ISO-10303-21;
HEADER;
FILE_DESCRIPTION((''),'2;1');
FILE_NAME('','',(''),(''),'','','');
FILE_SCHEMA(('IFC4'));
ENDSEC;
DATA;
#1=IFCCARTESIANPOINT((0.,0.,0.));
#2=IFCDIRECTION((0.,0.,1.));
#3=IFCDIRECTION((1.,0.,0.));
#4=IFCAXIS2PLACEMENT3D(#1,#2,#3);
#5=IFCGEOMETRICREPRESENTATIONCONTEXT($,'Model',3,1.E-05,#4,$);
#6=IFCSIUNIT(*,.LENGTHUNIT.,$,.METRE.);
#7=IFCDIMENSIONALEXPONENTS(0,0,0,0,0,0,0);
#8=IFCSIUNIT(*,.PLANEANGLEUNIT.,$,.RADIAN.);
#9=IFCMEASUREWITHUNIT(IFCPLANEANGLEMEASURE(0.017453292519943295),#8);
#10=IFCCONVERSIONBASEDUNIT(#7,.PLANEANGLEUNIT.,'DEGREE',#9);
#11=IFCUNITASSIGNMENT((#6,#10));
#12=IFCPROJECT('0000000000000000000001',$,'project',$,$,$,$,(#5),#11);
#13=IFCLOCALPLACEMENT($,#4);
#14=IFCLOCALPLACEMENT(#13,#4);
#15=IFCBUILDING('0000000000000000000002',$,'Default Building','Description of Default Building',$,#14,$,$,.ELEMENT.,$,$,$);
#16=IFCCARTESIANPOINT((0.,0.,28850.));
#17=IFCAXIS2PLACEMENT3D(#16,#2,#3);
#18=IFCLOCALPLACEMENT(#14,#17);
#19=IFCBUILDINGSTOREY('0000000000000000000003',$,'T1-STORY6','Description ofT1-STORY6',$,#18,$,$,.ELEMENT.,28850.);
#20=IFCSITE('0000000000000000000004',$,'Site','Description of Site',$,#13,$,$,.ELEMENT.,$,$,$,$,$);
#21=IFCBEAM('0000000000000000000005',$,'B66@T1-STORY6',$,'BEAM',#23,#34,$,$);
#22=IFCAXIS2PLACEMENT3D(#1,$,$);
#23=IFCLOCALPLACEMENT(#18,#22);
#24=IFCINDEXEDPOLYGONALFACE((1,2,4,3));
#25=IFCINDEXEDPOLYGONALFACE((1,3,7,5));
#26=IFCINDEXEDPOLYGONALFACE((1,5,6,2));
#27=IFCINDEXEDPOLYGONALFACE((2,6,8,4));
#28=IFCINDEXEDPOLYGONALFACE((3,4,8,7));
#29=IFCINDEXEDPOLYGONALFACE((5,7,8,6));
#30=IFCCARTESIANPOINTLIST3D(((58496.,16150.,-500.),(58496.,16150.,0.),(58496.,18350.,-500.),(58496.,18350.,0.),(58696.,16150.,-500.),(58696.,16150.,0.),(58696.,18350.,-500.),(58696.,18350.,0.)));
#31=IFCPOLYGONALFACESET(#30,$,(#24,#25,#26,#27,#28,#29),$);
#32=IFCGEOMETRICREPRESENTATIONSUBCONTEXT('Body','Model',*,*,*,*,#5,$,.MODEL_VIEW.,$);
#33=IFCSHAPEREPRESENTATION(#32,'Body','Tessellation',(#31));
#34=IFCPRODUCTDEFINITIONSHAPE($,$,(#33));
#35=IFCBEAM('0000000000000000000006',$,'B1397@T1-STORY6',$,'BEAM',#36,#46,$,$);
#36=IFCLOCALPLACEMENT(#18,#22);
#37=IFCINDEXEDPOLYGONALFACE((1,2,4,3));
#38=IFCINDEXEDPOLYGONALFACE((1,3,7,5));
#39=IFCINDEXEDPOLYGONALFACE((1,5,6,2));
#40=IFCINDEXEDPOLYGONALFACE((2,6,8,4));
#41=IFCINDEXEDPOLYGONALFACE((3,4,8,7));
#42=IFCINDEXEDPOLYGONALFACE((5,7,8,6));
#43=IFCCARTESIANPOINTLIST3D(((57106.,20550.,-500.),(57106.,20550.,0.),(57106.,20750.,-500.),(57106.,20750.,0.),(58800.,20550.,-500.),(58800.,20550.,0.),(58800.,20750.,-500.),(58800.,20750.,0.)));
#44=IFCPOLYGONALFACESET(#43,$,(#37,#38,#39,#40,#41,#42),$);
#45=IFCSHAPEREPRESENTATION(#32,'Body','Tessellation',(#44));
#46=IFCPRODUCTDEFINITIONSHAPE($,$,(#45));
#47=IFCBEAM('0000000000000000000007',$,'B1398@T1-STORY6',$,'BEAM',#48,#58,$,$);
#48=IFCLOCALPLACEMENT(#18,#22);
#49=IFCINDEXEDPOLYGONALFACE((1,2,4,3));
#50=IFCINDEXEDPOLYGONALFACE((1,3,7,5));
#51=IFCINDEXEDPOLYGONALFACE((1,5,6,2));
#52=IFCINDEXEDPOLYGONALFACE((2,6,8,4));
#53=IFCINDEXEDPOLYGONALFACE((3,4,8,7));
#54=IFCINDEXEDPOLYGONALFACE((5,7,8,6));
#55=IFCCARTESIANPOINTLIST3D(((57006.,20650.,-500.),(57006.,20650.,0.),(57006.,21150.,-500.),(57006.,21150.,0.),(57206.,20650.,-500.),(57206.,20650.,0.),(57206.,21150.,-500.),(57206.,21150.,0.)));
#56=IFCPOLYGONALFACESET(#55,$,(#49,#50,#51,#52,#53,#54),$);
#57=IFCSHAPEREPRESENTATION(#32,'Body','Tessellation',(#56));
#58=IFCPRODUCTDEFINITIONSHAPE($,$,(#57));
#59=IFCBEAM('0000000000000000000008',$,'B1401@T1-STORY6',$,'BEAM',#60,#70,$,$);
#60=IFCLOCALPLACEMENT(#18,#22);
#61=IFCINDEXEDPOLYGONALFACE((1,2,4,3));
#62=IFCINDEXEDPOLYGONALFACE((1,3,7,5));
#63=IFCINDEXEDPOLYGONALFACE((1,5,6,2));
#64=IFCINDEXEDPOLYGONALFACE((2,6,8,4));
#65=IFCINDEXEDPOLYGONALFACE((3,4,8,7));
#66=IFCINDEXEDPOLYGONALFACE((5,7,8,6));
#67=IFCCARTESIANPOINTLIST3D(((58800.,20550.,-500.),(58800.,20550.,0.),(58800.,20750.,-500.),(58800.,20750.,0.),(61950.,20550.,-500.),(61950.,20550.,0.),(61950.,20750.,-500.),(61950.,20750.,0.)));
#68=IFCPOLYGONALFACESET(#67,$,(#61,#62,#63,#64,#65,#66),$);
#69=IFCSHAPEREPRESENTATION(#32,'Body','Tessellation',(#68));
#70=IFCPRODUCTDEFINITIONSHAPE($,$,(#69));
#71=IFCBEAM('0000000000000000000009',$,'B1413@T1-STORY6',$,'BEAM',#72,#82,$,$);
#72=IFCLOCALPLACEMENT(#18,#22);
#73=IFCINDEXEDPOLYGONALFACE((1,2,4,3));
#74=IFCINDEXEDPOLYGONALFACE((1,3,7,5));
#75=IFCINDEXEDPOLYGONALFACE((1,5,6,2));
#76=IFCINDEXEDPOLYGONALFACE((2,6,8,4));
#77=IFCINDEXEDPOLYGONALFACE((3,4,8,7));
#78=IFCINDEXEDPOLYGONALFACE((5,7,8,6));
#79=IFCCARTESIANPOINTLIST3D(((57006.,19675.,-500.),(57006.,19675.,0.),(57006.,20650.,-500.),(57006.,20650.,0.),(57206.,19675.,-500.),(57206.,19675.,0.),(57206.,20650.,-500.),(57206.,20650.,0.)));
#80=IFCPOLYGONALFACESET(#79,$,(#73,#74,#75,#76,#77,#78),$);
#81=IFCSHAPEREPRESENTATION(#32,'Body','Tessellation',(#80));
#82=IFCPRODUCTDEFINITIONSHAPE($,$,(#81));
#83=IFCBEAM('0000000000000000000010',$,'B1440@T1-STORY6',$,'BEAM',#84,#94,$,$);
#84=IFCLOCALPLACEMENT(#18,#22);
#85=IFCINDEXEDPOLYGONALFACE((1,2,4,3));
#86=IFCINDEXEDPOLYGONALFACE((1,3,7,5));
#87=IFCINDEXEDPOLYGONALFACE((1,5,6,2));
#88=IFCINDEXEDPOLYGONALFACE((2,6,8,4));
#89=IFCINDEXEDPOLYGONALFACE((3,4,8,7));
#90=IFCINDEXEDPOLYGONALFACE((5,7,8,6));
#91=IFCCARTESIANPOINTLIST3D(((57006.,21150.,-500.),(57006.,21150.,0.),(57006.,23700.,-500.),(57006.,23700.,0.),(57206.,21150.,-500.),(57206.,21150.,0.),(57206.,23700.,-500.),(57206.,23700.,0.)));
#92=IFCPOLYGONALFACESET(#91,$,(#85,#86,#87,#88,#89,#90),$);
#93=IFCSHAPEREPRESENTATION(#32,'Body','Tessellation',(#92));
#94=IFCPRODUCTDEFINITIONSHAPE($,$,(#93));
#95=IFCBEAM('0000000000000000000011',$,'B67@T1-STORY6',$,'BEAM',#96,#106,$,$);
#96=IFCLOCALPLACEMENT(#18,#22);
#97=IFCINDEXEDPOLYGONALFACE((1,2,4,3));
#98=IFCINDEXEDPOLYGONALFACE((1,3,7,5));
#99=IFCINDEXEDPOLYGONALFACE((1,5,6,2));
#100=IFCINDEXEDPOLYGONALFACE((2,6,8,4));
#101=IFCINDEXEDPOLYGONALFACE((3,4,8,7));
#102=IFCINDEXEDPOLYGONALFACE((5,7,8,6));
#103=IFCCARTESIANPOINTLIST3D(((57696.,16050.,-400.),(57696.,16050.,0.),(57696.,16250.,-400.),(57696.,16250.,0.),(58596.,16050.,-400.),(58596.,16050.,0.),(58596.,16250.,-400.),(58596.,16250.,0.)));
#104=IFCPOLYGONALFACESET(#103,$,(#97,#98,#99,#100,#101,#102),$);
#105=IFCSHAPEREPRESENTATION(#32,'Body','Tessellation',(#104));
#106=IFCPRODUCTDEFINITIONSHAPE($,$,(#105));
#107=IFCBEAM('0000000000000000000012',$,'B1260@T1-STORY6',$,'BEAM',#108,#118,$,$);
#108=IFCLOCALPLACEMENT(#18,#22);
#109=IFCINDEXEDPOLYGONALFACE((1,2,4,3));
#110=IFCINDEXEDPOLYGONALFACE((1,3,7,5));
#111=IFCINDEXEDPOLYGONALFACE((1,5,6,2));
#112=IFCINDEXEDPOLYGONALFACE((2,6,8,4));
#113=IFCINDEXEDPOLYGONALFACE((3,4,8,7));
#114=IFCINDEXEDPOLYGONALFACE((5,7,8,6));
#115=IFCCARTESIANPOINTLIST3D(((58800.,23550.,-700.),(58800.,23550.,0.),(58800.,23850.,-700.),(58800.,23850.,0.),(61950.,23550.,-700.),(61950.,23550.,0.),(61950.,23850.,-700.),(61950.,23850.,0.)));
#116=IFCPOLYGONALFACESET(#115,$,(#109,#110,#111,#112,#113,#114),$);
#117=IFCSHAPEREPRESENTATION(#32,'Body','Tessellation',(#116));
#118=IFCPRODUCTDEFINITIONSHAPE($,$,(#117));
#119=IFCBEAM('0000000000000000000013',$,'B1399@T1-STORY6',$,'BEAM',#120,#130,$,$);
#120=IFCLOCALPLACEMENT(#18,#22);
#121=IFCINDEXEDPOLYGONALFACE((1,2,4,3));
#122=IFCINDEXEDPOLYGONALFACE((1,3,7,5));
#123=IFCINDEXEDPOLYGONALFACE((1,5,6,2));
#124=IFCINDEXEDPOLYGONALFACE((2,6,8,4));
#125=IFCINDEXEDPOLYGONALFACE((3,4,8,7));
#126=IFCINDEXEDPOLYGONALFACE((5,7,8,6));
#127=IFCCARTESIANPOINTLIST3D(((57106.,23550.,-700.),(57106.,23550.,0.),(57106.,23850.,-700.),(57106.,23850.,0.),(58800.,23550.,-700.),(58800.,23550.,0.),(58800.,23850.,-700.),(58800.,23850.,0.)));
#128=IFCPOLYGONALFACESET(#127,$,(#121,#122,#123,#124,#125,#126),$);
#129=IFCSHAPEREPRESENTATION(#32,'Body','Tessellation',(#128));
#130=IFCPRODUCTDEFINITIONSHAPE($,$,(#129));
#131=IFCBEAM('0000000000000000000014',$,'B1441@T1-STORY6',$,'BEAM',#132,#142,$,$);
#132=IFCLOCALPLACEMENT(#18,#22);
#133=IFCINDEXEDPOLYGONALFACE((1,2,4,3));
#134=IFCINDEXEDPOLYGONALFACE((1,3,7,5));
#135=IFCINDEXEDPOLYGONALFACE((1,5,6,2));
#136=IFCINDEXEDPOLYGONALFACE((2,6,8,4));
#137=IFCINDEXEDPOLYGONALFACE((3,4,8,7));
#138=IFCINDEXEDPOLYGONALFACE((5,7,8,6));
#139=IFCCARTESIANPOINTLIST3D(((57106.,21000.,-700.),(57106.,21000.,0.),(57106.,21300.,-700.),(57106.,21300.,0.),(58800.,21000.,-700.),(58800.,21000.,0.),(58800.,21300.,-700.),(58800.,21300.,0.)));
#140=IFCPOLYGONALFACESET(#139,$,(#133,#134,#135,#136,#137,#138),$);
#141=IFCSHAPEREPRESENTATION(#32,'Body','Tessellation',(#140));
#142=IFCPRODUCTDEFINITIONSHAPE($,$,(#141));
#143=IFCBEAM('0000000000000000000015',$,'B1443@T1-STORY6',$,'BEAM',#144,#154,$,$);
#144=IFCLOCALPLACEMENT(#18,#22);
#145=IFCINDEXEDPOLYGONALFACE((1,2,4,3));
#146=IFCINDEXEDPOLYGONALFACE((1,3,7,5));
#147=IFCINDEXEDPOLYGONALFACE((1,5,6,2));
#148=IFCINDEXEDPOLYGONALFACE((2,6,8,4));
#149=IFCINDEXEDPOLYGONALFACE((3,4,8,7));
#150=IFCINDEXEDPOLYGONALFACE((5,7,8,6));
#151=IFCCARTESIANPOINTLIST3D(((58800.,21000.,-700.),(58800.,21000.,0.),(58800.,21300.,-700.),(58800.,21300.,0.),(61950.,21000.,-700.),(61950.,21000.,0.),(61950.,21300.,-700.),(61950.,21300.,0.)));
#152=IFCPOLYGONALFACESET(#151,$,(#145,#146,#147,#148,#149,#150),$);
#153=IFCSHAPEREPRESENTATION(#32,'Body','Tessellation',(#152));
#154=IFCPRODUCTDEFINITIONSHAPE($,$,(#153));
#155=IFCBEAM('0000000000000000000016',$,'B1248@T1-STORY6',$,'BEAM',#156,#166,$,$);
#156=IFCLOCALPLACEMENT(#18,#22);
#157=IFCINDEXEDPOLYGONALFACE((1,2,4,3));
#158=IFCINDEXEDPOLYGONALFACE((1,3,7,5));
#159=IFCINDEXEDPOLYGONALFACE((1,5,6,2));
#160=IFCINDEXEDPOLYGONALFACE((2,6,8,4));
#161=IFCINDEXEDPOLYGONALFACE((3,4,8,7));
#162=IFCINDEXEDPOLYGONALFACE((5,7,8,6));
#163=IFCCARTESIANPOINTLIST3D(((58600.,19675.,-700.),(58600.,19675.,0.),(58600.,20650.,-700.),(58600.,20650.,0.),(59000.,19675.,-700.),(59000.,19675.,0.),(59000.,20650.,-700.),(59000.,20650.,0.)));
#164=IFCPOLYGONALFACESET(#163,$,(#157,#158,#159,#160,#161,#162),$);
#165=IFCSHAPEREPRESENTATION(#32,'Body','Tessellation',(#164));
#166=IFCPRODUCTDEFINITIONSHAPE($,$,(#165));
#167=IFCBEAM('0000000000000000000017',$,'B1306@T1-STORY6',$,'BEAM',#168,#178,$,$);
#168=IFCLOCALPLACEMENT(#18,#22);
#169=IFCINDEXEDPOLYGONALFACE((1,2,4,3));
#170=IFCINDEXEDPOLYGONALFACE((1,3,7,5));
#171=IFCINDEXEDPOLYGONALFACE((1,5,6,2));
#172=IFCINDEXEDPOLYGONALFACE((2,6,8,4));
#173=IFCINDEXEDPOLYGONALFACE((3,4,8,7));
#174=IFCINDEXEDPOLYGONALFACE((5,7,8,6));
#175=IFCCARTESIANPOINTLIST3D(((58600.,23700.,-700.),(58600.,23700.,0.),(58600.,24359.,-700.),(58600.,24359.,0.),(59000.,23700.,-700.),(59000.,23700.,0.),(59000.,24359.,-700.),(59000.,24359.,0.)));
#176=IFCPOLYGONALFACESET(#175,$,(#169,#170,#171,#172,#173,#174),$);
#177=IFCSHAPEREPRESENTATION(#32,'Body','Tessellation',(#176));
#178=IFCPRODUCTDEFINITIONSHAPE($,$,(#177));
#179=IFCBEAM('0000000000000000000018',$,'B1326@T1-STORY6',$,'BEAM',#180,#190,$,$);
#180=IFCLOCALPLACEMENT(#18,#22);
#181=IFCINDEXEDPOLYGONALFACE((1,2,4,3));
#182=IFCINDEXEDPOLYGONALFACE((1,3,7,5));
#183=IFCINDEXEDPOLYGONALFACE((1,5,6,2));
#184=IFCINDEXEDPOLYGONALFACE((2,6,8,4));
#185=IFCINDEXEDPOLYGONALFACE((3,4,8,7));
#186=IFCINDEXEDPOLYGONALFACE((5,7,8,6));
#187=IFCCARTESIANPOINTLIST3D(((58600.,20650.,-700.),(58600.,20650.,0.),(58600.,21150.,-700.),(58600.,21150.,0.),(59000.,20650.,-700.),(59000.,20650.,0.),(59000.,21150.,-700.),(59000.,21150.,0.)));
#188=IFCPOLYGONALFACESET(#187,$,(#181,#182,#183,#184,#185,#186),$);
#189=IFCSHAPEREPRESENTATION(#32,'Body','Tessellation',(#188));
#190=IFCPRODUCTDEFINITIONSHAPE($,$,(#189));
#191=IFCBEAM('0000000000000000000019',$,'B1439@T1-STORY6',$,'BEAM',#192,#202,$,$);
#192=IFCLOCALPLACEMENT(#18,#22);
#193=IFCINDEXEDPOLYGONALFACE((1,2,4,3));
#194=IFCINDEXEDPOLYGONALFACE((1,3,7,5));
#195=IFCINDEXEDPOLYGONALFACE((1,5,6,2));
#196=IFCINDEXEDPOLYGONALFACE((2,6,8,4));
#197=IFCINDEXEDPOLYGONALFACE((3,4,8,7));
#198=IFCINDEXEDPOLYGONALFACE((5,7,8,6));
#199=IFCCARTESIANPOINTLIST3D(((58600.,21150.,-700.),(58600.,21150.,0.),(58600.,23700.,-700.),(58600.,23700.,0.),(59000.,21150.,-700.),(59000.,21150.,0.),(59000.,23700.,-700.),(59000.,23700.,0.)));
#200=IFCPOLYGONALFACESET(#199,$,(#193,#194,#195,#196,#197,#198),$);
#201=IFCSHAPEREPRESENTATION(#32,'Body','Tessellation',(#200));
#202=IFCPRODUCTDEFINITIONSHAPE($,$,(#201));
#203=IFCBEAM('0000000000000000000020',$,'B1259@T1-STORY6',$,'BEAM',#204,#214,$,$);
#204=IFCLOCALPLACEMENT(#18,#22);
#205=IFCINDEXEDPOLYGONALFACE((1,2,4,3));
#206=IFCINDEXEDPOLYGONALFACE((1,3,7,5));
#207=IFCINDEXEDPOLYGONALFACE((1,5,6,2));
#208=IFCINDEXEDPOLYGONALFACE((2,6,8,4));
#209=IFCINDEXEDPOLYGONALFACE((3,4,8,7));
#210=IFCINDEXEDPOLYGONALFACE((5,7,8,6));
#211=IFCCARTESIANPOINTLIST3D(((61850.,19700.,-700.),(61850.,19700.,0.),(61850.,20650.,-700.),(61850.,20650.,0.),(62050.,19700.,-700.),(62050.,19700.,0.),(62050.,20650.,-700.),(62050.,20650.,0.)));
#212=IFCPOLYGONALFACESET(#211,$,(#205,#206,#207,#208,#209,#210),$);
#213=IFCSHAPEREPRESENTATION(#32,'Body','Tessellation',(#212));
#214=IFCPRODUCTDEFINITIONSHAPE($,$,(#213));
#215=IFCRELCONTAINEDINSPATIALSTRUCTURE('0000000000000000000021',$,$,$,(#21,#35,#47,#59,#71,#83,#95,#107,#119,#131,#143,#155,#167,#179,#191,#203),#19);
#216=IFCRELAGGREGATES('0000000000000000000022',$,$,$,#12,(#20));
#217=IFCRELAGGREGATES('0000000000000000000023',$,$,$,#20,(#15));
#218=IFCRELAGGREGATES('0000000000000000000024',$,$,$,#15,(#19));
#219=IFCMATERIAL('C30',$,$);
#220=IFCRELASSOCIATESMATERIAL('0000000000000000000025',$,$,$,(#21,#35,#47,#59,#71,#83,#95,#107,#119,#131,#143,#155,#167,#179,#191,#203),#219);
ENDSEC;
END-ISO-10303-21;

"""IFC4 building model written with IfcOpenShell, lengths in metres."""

from ifc_helpers import new_model, entity, si_unit, converted_unit, frame, origin_with_axes, place, context, subcontext, project, spatial, rectangle, extrude, material, element, save


model = new_model("IFC4")

# Units and contexts
model_context = context("Model", 3, precision=1e-05, world=origin_with_axes())
body_context = subcontext(model_context, "Body", "Model", "MODEL_VIEW")
ifc_project = project(units=[si_unit("LENGTHUNIT", "METRE"), converted_unit("PLANEANGLEUNIT", "DEGREE", entity("IfcPlaneAngleMeasure", 0.017453292519943295), si_unit("PLANEANGLEUNIT", "RADIAN"), dimensions=[0, 0, 0, 0, 0, 0, 0])], contexts=[model_context])

# Site, building, storey
site_placement = place(None, origin_with_axes())
site = spatial("IfcSite", under=ifc_project, at=site_placement, Name="Site", Description="Description of Site", CompositionType="ELEMENT")
building_placement = place(site_placement, origin_with_axes())
building = spatial("IfcBuilding", under=site, at=building_placement, Name="Default Building", Description="Description of Default Building", CompositionType="ELEMENT")
storey_placement = place(building_placement, frame((0.0, 0.0, 28850.0), z_axis=(0.0, 0.0, 1.0), x_axis=(1.0, 0.0, 0.0)))
storey = spatial("IfcBuildingStorey", under=building, at=storey_placement, Name="T1-STORY6", Description="Description ofT1-STORY6", CompositionType="ELEMENT", Elevation=28850.0)

# Beams
ifc_material_1 = material(Name="C30")
beam_1_placement = place(storey_placement, frame((58596.0, 16150.0, -250.0), z_axis=(0.0, 1.0, 0.0), x_axis=(-1.0, 0.0, 0.0)))
element("IfcBeam", 1, at=beam_1_placement, inside=storey, material=ifc_material_1, Name="B66@T1-STORY6", ObjectType="BEAM", context=body_context, shape_type="SweptSolid", body=[
    extrude(rectangle(XDim=200.0, YDim=500.0), origin_with_axes(), (0.0, 0.0, 1.0), 2200.0),
])
beam_2_placement = place(storey_placement, frame((57106.0, 20650.0, -250.0), z_axis=(1.0, 0.0, 0.0), x_axis=(0.0, 1.0, 0.0)))
element("IfcBeam", 2, at=beam_2_placement, inside=storey, material=ifc_material_1, Name="B1397@T1-STORY6", ObjectType="BEAM", context=body_context, shape_type="SweptSolid", body=[
    extrude(rectangle(XDim=200.0, YDim=500.0), origin_with_axes(), (0.0, 0.0, 1.0), 1694.0),
])
beam_3_placement = place(storey_placement, frame((57106.0, 20650.0, -250.0), z_axis=(0.0, 1.0, 0.0), x_axis=(-1.0, 0.0, 0.0)))
element("IfcBeam", 3, at=beam_3_placement, inside=storey, material=ifc_material_1, Name="B1398@T1-STORY6", ObjectType="BEAM", context=body_context, shape_type="SweptSolid", body=[
    extrude(rectangle(XDim=200.0, YDim=500.0), origin_with_axes(), (0.0, 0.0, 1.0), 500.0),
])
beam_4_placement = place(storey_placement, frame((58800.0, 20650.0, -250.0), z_axis=(1.0, 0.0, 0.0), x_axis=(0.0, 1.0, 0.0)))
element("IfcBeam", 4, at=beam_4_placement, inside=storey, material=ifc_material_1, Name="B1401@T1-STORY6", ObjectType="BEAM", context=body_context, shape_type="SweptSolid", body=[
    extrude(rectangle(XDim=200.0, YDim=500.0), origin_with_axes(), (0.0, 0.0, 1.0), 3150.0),
])
beam_5_placement = place(storey_placement, frame((57106.0, 19675.0, -250.0), z_axis=(0.0, 1.0, 0.0), x_axis=(-1.0, 0.0, 0.0)))
element("IfcBeam", 5, at=beam_5_placement, inside=storey, material=ifc_material_1, Name="B1413@T1-STORY6", ObjectType="BEAM", context=body_context, shape_type="SweptSolid", body=[
    extrude(rectangle(XDim=200.0, YDim=500.0), origin_with_axes(), (0.0, 0.0, 1.0), 975.0),
])
beam_6_placement = place(storey_placement, frame((57106.0, 21150.0, -250.0), z_axis=(0.0, 1.0, 0.0), x_axis=(-1.0, 0.0, 0.0)))
element("IfcBeam", 6, at=beam_6_placement, inside=storey, material=ifc_material_1, Name="B1440@T1-STORY6", ObjectType="BEAM", context=body_context, shape_type="SweptSolid", body=[
    extrude(rectangle(XDim=200.0, YDim=500.0), origin_with_axes(), (0.0, 0.0, 1.0), 2550.0),
])
beam_7_placement = place(storey_placement, frame((57696.0, 16150.0, -200.0), z_axis=(1.0, 0.0, 0.0), x_axis=(0.0, 1.0, 0.0)))
element("IfcBeam", 7, at=beam_7_placement, inside=storey, material=ifc_material_1, Name="B67@T1-STORY6", ObjectType="BEAM", context=body_context, shape_type="SweptSolid", body=[
    extrude(rectangle(XDim=200.0, YDim=400.0), origin_with_axes(), (0.0, 0.0, 1.0), 900.0),
])
beam_8_placement = place(storey_placement, frame((58800.0, 23700.0, -350.0), z_axis=(1.0, 0.0, 0.0), x_axis=(0.0, 1.0, 0.0)))
element("IfcBeam", 8, at=beam_8_placement, inside=storey, material=ifc_material_1, Name="B1260@T1-STORY6", ObjectType="BEAM", context=body_context, shape_type="SweptSolid", body=[
    extrude(rectangle(XDim=300.0, YDim=700.0), origin_with_axes(), (0.0, 0.0, 1.0), 3150.0),
])
for number, where, z_axis, x_axis, name in (
    (9, (57106.0, 23700.0, -350.0), (1.0, 0.0, 0.0), (0.0, 1.0, 0.0), "B1399@T1-STORY6"),
    (10, (57106.0, 21150.0, -350.0), (1.0, 0.0, 0.0), (0.0, 1.0, 0.0), "B1441@T1-STORY6"),
):
    element("IfcBeam", number, at=place(storey_placement, frame(where, z_axis=z_axis, x_axis=x_axis)), inside=storey, material=ifc_material_1, Name=name, ObjectType="BEAM", context=body_context, shape_type="SweptSolid", body=[
        extrude(rectangle(XDim=300.0, YDim=700.0), origin_with_axes(), (0.0, 0.0, 1.0), 1694.0),
    ])
beam_9_placement = place(storey_placement, frame((58800.0, 21150.0, -350.0), z_axis=(1.0, 0.0, 0.0), x_axis=(0.0, 1.0, 0.0)))
element("IfcBeam", 11, at=beam_9_placement, inside=storey, material=ifc_material_1, Name="B1443@T1-STORY6", ObjectType="BEAM", context=body_context, shape_type="SweptSolid", body=[
    extrude(rectangle(XDim=300.0, YDim=700.0), origin_with_axes(), (0.0, 0.0, 1.0), 3150.0),
])
beam_10_placement = place(storey_placement, frame((58800.0, 19675.0, -350.0), z_axis=(0.0, 1.0, 0.0), x_axis=(-1.0, 0.0, 0.0)))
element("IfcBeam", 12, at=beam_10_placement, inside=storey, material=ifc_material_1, Name="B1248@T1-STORY6", ObjectType="BEAM", context=body_context, shape_type="SweptSolid", body=[
    extrude(rectangle(XDim=400.0, YDim=700.0), origin_with_axes(), (0.0, 0.0, 1.0), 975.0),
])
beam_11_placement = place(storey_placement, frame((58800.0, 23700.0, -350.0), z_axis=(0.0, 1.0, 0.0), x_axis=(-1.0, 0.0, 0.0)))
element("IfcBeam", 13, at=beam_11_placement, inside=storey, material=ifc_material_1, Name="B1306@T1-STORY6", ObjectType="BEAM", context=body_context, shape_type="SweptSolid", body=[
    extrude(rectangle(XDim=400.0, YDim=700.0), origin_with_axes(), (0.0, 0.0, 1.0), 659.0),
])
beam_12_placement = place(storey_placement, frame((58800.0, 20650.0, -350.0), z_axis=(0.0, 1.0, 0.0), x_axis=(-1.0, 0.0, 0.0)))
element("IfcBeam", 14, at=beam_12_placement, inside=storey, material=ifc_material_1, Name="B1326@T1-STORY6", ObjectType="BEAM", context=body_context, shape_type="SweptSolid", body=[
    extrude(rectangle(XDim=400.0, YDim=700.0), origin_with_axes(), (0.0, 0.0, 1.0), 500.0),
])
beam_13_placement = place(storey_placement, frame((58800.0, 21150.0, -350.0), z_axis=(0.0, 1.0, 0.0), x_axis=(-1.0, 0.0, 0.0)))
element("IfcBeam", 15, at=beam_13_placement, inside=storey, material=ifc_material_1, Name="B1439@T1-STORY6", ObjectType="BEAM", context=body_context, shape_type="SweptSolid", body=[
    extrude(rectangle(XDim=400.0, YDim=700.0), origin_with_axes(), (0.0, 0.0, 1.0), 2550.0),
])
beam_14_placement = place(storey_placement, frame((61950.0, 19700.0, -350.0), z_axis=(0.0, 1.0, 0.0), x_axis=(-1.0, 0.0, 0.0)))
element("IfcBeam", 16, at=beam_14_placement, inside=storey, material=ifc_material_1, Name="B1259@T1-STORY6", ObjectType="BEAM", context=body_context, shape_type="SweptSolid", body=[
    extrude(rectangle(XDim=200.0, YDim=700.0), origin_with_axes(), (0.0, 0.0, 1.0), 950.0),
])

save(model, "model.ifc")
